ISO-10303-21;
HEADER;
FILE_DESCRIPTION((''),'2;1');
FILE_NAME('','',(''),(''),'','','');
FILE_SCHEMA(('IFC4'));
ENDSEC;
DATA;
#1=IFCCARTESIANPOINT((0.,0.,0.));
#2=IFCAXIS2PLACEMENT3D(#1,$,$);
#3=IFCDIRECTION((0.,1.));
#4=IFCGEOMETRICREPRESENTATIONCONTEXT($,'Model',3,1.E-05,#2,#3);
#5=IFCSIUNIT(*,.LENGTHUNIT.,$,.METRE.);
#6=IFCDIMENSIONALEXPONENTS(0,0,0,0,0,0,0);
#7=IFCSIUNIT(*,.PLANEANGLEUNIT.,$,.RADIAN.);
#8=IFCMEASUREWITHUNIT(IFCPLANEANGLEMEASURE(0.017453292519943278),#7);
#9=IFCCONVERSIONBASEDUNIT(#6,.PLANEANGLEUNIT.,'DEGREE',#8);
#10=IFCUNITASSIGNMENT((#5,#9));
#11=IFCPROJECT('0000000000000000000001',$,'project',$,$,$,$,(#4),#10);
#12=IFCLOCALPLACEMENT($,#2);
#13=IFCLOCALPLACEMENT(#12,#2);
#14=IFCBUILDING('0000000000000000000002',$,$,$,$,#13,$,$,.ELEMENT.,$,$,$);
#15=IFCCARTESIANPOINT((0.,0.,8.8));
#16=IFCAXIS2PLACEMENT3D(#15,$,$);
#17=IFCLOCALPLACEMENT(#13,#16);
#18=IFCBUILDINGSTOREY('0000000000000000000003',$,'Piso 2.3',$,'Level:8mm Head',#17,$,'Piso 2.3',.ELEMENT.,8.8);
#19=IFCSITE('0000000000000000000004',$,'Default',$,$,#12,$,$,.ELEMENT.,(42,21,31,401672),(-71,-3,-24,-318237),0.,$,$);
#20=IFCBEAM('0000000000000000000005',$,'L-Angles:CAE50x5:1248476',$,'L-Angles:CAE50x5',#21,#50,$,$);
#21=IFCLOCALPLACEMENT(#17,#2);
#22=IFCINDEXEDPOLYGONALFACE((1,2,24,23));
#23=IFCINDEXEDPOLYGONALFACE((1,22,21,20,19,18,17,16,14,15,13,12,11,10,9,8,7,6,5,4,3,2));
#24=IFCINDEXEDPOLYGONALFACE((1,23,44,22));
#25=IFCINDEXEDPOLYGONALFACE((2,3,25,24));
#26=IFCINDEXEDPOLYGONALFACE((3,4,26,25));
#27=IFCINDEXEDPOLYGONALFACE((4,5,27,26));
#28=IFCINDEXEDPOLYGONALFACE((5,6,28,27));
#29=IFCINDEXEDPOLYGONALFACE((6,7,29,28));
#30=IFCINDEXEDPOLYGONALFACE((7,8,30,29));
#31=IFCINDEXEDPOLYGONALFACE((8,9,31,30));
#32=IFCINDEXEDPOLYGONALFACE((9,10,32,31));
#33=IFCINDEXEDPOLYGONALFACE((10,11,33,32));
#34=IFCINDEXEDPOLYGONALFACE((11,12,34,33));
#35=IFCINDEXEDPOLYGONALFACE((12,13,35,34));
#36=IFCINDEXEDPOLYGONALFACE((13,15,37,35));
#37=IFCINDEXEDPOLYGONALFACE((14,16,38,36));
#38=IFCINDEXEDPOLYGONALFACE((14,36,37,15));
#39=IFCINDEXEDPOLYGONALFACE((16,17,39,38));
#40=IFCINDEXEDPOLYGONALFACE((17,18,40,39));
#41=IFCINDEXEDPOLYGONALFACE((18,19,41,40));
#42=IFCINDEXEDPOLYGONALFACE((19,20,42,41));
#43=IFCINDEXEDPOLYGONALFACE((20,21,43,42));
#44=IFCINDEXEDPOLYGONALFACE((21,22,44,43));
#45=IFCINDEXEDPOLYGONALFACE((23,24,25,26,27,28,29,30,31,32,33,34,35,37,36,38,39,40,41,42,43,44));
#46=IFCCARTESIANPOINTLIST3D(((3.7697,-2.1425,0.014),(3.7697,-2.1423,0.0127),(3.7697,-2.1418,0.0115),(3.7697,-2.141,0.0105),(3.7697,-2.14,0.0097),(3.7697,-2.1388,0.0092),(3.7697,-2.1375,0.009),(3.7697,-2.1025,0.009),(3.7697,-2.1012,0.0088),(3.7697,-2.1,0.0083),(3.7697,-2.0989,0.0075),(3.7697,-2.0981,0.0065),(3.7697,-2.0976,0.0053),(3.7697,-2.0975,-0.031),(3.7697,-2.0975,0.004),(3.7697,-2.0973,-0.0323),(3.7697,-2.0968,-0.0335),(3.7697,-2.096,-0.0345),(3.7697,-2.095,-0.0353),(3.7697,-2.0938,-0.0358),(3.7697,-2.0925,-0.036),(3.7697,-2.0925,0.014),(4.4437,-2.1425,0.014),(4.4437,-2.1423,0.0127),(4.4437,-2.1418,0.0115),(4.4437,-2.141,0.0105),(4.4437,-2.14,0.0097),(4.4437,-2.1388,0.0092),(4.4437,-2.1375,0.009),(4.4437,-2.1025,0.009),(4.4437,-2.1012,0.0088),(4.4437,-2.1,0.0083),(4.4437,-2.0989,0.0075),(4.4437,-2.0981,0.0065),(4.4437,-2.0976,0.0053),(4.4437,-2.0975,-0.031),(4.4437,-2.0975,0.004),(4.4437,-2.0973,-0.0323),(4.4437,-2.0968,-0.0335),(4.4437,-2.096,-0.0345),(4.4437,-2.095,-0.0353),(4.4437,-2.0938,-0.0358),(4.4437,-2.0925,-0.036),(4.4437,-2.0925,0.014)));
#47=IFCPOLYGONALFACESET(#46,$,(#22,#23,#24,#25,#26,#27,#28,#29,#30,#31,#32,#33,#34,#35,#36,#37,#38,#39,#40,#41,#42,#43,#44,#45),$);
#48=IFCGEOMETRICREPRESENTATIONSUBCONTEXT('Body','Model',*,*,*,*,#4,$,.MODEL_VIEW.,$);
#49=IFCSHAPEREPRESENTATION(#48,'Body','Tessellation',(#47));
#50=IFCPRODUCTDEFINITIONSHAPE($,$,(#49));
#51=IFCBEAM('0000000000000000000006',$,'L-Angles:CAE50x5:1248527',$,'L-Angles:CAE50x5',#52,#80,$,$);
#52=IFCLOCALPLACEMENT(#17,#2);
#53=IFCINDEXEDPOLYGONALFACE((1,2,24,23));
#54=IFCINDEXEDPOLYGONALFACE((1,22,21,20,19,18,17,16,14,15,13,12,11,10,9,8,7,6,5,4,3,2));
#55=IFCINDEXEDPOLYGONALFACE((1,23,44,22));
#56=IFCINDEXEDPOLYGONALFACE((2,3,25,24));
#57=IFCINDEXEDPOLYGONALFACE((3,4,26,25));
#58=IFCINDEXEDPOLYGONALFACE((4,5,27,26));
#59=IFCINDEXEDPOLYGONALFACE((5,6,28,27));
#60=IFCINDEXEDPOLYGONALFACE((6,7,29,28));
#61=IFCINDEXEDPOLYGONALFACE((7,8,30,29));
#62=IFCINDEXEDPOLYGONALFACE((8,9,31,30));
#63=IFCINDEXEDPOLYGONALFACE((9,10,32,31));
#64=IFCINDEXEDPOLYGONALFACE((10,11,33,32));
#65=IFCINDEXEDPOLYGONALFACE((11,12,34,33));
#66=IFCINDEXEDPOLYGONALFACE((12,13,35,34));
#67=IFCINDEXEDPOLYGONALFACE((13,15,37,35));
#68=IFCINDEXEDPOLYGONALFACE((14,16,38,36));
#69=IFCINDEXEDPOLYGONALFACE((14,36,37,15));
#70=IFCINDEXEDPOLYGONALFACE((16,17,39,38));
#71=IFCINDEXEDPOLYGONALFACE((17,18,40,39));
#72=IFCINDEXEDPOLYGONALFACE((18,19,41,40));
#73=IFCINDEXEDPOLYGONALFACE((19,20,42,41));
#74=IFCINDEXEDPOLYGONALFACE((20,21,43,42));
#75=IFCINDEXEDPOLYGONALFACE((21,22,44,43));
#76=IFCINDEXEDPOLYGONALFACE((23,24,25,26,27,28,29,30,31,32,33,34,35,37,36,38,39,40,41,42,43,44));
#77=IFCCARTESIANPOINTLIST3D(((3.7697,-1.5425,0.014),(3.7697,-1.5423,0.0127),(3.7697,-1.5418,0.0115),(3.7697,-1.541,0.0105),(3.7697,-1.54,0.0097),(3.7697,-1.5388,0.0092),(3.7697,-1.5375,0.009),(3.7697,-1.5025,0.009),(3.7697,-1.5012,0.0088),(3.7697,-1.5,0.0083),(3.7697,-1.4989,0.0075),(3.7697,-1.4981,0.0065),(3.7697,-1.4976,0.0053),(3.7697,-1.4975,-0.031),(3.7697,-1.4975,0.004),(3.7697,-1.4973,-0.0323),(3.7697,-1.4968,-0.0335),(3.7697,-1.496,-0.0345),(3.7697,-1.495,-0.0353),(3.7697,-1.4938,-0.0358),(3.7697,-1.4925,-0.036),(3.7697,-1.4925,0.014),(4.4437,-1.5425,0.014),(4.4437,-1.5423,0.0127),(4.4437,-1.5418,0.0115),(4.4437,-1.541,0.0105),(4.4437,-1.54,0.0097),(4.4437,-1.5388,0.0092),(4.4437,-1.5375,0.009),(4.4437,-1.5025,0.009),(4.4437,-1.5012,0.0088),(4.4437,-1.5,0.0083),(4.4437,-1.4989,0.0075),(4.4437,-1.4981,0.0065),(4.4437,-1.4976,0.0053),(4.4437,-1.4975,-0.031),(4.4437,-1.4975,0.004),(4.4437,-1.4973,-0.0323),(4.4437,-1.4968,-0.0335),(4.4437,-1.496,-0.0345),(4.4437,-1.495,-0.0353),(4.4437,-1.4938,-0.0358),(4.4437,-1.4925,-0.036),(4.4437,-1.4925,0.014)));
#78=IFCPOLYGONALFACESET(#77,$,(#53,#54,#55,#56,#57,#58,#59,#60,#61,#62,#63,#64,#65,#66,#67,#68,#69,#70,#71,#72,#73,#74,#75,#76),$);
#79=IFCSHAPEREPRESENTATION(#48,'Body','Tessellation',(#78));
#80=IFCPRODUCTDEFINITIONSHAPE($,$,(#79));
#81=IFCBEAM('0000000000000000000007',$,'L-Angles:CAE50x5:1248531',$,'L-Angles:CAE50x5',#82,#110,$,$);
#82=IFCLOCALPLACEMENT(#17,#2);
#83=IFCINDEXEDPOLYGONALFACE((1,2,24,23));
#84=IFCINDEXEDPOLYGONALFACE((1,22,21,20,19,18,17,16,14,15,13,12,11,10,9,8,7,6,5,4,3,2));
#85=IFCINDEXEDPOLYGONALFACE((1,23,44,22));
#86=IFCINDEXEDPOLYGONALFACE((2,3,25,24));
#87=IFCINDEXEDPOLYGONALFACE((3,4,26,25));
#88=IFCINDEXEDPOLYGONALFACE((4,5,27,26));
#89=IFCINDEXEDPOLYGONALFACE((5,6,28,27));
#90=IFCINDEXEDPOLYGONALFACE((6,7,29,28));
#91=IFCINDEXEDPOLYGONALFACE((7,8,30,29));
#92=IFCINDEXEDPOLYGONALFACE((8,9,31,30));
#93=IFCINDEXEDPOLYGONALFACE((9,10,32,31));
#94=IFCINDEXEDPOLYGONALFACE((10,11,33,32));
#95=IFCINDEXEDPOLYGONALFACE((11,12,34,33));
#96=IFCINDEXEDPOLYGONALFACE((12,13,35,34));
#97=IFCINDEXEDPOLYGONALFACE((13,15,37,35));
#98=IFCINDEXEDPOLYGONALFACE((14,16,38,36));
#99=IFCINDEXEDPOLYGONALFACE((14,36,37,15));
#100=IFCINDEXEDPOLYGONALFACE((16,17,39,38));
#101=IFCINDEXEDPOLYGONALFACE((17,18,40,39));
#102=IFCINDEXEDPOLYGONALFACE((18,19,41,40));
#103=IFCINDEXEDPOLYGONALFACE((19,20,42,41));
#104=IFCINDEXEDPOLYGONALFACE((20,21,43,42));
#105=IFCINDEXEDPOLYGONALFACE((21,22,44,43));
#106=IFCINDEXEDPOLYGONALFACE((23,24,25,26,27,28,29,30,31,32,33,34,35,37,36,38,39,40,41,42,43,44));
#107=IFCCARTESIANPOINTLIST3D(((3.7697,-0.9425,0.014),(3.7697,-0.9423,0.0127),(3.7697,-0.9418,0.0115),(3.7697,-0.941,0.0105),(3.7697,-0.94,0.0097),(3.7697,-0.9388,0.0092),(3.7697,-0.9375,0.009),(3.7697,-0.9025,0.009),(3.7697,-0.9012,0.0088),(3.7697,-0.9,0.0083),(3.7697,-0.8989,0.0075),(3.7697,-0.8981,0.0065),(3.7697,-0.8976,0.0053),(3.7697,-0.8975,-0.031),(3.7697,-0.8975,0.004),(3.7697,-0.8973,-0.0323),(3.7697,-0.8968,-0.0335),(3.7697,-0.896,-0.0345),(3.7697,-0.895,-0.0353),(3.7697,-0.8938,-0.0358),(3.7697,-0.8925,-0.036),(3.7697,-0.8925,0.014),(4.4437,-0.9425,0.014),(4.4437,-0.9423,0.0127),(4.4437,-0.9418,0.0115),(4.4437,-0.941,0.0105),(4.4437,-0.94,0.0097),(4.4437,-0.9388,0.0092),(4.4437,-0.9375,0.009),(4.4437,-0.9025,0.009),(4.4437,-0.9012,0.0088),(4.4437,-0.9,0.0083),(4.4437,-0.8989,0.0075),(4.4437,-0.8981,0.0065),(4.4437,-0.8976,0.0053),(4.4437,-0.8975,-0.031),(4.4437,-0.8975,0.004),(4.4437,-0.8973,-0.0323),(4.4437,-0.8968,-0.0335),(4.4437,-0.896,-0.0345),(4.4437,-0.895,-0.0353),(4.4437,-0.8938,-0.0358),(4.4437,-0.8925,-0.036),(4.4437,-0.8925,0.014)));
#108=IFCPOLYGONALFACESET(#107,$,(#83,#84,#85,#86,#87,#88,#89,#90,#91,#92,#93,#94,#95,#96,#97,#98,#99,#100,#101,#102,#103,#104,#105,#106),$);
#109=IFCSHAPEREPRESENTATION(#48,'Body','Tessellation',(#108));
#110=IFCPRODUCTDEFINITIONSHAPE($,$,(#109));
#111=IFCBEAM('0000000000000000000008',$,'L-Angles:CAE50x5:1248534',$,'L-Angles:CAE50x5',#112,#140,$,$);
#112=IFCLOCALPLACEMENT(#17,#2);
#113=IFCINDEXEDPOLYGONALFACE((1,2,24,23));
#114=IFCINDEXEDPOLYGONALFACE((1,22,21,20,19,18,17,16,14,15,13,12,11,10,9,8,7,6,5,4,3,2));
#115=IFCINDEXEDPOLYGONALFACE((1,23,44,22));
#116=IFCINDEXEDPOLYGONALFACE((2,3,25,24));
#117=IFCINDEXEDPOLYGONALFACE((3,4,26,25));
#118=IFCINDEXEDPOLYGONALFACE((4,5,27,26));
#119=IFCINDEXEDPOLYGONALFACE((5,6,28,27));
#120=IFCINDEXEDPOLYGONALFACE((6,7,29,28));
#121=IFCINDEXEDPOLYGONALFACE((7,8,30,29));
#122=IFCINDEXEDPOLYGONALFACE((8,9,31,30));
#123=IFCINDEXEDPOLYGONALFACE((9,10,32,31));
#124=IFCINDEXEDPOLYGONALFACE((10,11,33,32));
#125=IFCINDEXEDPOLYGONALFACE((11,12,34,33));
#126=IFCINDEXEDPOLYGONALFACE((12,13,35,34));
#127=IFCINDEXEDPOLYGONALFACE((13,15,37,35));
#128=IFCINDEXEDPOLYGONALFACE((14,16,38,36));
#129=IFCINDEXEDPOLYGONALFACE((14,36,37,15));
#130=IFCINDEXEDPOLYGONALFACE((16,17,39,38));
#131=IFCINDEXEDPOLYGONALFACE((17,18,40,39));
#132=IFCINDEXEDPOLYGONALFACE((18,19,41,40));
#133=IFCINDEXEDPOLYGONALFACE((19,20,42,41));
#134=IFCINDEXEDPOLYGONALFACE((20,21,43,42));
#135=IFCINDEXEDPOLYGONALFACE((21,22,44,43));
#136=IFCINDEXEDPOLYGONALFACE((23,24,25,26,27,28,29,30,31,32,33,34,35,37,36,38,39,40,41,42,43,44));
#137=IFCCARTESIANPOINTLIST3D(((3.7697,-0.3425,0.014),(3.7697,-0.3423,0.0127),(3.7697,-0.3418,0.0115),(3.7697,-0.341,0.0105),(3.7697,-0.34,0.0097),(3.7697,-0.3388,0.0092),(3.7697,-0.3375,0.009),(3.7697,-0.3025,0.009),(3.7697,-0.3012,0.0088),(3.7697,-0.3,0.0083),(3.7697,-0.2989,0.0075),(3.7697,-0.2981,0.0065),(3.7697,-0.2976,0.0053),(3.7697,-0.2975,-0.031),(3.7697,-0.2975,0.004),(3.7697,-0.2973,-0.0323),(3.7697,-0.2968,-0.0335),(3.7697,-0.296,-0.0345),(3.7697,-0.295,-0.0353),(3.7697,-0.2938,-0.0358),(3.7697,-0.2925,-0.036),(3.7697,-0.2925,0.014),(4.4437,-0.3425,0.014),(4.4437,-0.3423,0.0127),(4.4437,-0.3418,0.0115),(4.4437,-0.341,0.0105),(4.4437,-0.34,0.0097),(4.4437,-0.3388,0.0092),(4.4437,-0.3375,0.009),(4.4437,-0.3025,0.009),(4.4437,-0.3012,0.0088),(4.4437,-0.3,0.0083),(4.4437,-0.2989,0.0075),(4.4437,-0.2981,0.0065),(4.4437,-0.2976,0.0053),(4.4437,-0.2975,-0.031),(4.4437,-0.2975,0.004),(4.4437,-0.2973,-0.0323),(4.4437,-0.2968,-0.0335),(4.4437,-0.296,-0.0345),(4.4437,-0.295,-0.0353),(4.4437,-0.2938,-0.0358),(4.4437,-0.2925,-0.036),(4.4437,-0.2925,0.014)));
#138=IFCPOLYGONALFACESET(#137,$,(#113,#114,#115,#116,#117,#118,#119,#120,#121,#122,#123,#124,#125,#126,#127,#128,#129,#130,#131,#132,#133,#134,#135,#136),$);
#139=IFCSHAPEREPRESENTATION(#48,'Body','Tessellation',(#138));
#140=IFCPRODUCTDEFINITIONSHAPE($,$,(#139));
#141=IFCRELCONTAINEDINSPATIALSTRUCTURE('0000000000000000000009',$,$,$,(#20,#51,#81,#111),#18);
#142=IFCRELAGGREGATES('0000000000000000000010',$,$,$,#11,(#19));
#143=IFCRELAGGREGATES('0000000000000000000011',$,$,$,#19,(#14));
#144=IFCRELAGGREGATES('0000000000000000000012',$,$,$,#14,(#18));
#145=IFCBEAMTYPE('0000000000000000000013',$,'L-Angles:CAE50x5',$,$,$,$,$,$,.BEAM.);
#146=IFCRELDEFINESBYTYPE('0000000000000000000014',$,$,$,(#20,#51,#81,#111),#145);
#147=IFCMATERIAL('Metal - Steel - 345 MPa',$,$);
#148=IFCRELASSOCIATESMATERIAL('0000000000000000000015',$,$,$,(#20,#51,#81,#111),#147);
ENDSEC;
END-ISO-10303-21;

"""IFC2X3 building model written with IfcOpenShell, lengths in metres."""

from ifc_helpers import new_model, entity, si_unit, converted_unit, direction, frame, frame_2d, origin, place, context, subcontext, project, spatial, polyline, circle_curve, parameter, trimmed, segment, composite_curve, outline, extrude, material, type_object, element, save


model = new_model("IFC2X3")

# Units and contexts
model_context = context("Model", 3, precision=1e-05, world=origin(), true_north=direction((0.0, 1.0)))
body_context = subcontext(model_context, "Body", "Model", "MODEL_VIEW")
ifc_project = project(units=[si_unit("LENGTHUNIT", "METRE"), converted_unit("PLANEANGLEUNIT", "DEGREE", entity("IfcPlaneAngleMeasure", 0.017453292519943278), si_unit("PLANEANGLEUNIT", "RADIAN"), dimensions=[0, 0, 0, 0, 0, 0, 0])], contexts=[model_context])

# Site, building, storey
site_placement = place(None, origin())
site = spatial("IfcSite", under=ifc_project, at=site_placement, Name="Default", CompositionType="ELEMENT", RefLatitude=(42, 21, 31, 401672), RefLongitude=(-71, -3, -24, -318237), RefElevation=0.0)
building_placement = place(site_placement, origin())
building = spatial("IfcBuilding", under=site, at=building_placement, CompositionType="ELEMENT")
storey_placement = place(building_placement, frame((0.0, 0.0, 8.8)))
storey = spatial("IfcBuildingStorey", under=building, at=storey_placement, Name="Piso 2.3", ObjectType="Level:8mm Head", LongName="Piso 2.3", CompositionType="ELEMENT", Elevation=8.8)

# Shared definitions
ifc_material_1 = material(Name="Metal - Steel - 345 MPa")

# Beams
beam_type_1 = type_object("IfcBeamType", Name="L-Angles:CAE50x5", PredefinedType="BEAM")
beam_1_placement = place(storey_placement, frame((3.7067, -2.1065, 0.0)))
element("IfcBeam", 1, at=beam_1_placement, inside=storey, type_object=beam_type_1, material=ifc_material_1, Name="L-Angles:CAE50x5:1248476", ObjectType="L-Angles:CAE50x5", context=body_context, shape_type="SweptSolid", body=[
    extrude(outline(composite_curve([segment(polyline([(-0.0336, -0.0164), (0.0164, -0.0164)]), True, "CONTINUOUS"), segment(polyline([(0.0164, -0.0164), (0.0164, 0.0336)]), True, "CONTINUOUS"), segment(trimmed(circle_curve(frame_2d((0.0164, 0.0286), x_axis=(0.0, 1.0)), 0.005), [parameter(0.0)], [parameter(90.0)], True, "PARAMETER"), True, "CONTINUOUS"), segment(polyline([(0.0114, 0.0286), (0.0114, -0.0064)]), True, "CONTINUOUS"), segment(trimmed(circle_curve(frame_2d((0.0064, -0.0064), x_axis=(1.0, 0.0)), 0.005), [parameter(270.0)], [parameter(0.0)], True, "PARAMETER"), False, "CONTINUOUS"), segment(polyline([(0.0064, -0.0114), (-0.0286, -0.0114)]), True, "CONTINUOUS"), segment(trimmed(circle_curve(frame_2d((-0.0286, -0.0164), x_axis=(0.0, 1.0)), 0.005), [parameter(0.0)], [parameter(90.0)], True, "PARAMETER"), True, "CONTINUOUS")], self_intersect=False)), frame((0.063, -0.0024, -0.0024), z_axis=(1.0, 0.0, 0.0), x_axis=(0.0, 0.0, 1.0)), (0.0, 0.0, 1.0), 0.674),
])
beam_2_placement = place(storey_placement, frame((3.7067, -1.5065, 0.0)))
element("IfcBeam", 2, at=beam_2_placement, inside=storey, type_object=beam_type_1, material=ifc_material_1, Name="L-Angles:CAE50x5:1248527", ObjectType="L-Angles:CAE50x5", context=body_context, shape_type="SweptSolid", body=[
    extrude(outline(composite_curve([segment(polyline([(-0.0336, -0.0164), (0.0164, -0.0164)]), True, "CONTINUOUS"), segment(polyline([(0.0164, -0.0164), (0.0164, 0.0336)]), True, "CONTINUOUS"), segment(trimmed(circle_curve(frame_2d((0.0164, 0.0286), x_axis=(0.0, 1.0)), 0.005), [parameter(0.0)], [parameter(90.0)], True, "PARAMETER"), True, "CONTINUOUS"), segment(polyline([(0.0114, 0.0286), (0.0114, -0.0064)]), True, "CONTINUOUS"), segment(trimmed(circle_curve(frame_2d((0.0064, -0.0064), x_axis=(1.0, 0.0)), 0.005), [parameter(270.0)], [parameter(0.0)], True, "PARAMETER"), False, "CONTINUOUS"), segment(polyline([(0.0064, -0.0114), (-0.0286, -0.0114)]), True, "CONTINUOUS"), segment(trimmed(circle_curve(frame_2d((-0.0286, -0.0164), x_axis=(0.0, 1.0)), 0.005), [parameter(0.0)], [parameter(90.0)], True, "PARAMETER"), True, "CONTINUOUS")], self_intersect=False)), frame((0.063, -0.0024, -0.0024), z_axis=(1.0, 0.0, 0.0), x_axis=(0.0, 0.0, 1.0)), (0.0, 0.0, 1.0), 0.674),
])
beam_3_placement = place(storey_placement, frame((3.7067, -0.9065, 0.0)))
element("IfcBeam", 3, at=beam_3_placement, inside=storey, type_object=beam_type_1, material=ifc_material_1, Name="L-Angles:CAE50x5:1248531", ObjectType="L-Angles:CAE50x5", context=body_context, shape_type="SweptSolid", body=[
    extrude(outline(composite_curve([segment(polyline([(-0.0336, -0.0164), (0.0164, -0.0164)]), True, "CONTINUOUS"), segment(polyline([(0.0164, -0.0164), (0.0164, 0.0336)]), True, "CONTINUOUS"), segment(trimmed(circle_curve(frame_2d((0.0164, 0.0286), x_axis=(0.0, 1.0)), 0.005), [parameter(0.0)], [parameter(90.0)], True, "PARAMETER"), True, "CONTINUOUS"), segment(polyline([(0.0114, 0.0286), (0.0114, -0.0064)]), True, "CONTINUOUS"), segment(trimmed(circle_curve(frame_2d((0.0064, -0.0064), x_axis=(1.0, 0.0)), 0.005), [parameter(270.0)], [parameter(0.0)], True, "PARAMETER"), False, "CONTINUOUS"), segment(polyline([(0.0064, -0.0114), (-0.0286, -0.0114)]), True, "CONTINUOUS"), segment(trimmed(circle_curve(frame_2d((-0.0286, -0.0164), x_axis=(0.0, 1.0)), 0.005), [parameter(0.0)], [parameter(90.0)], True, "PARAMETER"), True, "CONTINUOUS")], self_intersect=False)), frame((0.063, -0.0024, -0.0024), z_axis=(1.0, 0.0, 0.0), x_axis=(0.0, 0.0, 1.0)), (0.0, 0.0, 1.0), 0.674),
])
beam_4_placement = place(storey_placement, frame((3.7067, -0.3065, 0.0)))
element("IfcBeam", 4, at=beam_4_placement, inside=storey, type_object=beam_type_1, material=ifc_material_1, Name="L-Angles:CAE50x5:1248534", ObjectType="L-Angles:CAE50x5", context=body_context, shape_type="SweptSolid", body=[
    extrude(outline(composite_curve([segment(polyline([(-0.0336, -0.0164), (0.0164, -0.0164)]), True, "CONTINUOUS"), segment(polyline([(0.0164, -0.0164), (0.0164, 0.0336)]), True, "CONTINUOUS"), segment(trimmed(circle_curve(frame_2d((0.0164, 0.0286), x_axis=(0.0, 1.0)), 0.005), [parameter(0.0)], [parameter(90.0)], True, "PARAMETER"), True, "CONTINUOUS"), segment(polyline([(0.0114, 0.0286), (0.0114, -0.0064)]), True, "CONTINUOUS"), segment(trimmed(circle_curve(frame_2d((0.0064, -0.0064), x_axis=(1.0, 0.0)), 0.005), [parameter(270.0)], [parameter(0.0)], True, "PARAMETER"), False, "CONTINUOUS"), segment(polyline([(0.0064, -0.0114), (-0.0286, -0.0114)]), True, "CONTINUOUS"), segment(trimmed(circle_curve(frame_2d((-0.0286, -0.0164), x_axis=(0.0, 1.0)), 0.005), [parameter(0.0)], [parameter(90.0)], True, "PARAMETER"), True, "CONTINUOUS")], self_intersect=False)), frame((0.063, -0.0024, -0.0024), z_axis=(1.0, 0.0, 0.0), x_axis=(0.0, 0.0, 1.0)), (0.0, 0.0, 1.0), 0.674),
])

save(model, "model.ifc")
